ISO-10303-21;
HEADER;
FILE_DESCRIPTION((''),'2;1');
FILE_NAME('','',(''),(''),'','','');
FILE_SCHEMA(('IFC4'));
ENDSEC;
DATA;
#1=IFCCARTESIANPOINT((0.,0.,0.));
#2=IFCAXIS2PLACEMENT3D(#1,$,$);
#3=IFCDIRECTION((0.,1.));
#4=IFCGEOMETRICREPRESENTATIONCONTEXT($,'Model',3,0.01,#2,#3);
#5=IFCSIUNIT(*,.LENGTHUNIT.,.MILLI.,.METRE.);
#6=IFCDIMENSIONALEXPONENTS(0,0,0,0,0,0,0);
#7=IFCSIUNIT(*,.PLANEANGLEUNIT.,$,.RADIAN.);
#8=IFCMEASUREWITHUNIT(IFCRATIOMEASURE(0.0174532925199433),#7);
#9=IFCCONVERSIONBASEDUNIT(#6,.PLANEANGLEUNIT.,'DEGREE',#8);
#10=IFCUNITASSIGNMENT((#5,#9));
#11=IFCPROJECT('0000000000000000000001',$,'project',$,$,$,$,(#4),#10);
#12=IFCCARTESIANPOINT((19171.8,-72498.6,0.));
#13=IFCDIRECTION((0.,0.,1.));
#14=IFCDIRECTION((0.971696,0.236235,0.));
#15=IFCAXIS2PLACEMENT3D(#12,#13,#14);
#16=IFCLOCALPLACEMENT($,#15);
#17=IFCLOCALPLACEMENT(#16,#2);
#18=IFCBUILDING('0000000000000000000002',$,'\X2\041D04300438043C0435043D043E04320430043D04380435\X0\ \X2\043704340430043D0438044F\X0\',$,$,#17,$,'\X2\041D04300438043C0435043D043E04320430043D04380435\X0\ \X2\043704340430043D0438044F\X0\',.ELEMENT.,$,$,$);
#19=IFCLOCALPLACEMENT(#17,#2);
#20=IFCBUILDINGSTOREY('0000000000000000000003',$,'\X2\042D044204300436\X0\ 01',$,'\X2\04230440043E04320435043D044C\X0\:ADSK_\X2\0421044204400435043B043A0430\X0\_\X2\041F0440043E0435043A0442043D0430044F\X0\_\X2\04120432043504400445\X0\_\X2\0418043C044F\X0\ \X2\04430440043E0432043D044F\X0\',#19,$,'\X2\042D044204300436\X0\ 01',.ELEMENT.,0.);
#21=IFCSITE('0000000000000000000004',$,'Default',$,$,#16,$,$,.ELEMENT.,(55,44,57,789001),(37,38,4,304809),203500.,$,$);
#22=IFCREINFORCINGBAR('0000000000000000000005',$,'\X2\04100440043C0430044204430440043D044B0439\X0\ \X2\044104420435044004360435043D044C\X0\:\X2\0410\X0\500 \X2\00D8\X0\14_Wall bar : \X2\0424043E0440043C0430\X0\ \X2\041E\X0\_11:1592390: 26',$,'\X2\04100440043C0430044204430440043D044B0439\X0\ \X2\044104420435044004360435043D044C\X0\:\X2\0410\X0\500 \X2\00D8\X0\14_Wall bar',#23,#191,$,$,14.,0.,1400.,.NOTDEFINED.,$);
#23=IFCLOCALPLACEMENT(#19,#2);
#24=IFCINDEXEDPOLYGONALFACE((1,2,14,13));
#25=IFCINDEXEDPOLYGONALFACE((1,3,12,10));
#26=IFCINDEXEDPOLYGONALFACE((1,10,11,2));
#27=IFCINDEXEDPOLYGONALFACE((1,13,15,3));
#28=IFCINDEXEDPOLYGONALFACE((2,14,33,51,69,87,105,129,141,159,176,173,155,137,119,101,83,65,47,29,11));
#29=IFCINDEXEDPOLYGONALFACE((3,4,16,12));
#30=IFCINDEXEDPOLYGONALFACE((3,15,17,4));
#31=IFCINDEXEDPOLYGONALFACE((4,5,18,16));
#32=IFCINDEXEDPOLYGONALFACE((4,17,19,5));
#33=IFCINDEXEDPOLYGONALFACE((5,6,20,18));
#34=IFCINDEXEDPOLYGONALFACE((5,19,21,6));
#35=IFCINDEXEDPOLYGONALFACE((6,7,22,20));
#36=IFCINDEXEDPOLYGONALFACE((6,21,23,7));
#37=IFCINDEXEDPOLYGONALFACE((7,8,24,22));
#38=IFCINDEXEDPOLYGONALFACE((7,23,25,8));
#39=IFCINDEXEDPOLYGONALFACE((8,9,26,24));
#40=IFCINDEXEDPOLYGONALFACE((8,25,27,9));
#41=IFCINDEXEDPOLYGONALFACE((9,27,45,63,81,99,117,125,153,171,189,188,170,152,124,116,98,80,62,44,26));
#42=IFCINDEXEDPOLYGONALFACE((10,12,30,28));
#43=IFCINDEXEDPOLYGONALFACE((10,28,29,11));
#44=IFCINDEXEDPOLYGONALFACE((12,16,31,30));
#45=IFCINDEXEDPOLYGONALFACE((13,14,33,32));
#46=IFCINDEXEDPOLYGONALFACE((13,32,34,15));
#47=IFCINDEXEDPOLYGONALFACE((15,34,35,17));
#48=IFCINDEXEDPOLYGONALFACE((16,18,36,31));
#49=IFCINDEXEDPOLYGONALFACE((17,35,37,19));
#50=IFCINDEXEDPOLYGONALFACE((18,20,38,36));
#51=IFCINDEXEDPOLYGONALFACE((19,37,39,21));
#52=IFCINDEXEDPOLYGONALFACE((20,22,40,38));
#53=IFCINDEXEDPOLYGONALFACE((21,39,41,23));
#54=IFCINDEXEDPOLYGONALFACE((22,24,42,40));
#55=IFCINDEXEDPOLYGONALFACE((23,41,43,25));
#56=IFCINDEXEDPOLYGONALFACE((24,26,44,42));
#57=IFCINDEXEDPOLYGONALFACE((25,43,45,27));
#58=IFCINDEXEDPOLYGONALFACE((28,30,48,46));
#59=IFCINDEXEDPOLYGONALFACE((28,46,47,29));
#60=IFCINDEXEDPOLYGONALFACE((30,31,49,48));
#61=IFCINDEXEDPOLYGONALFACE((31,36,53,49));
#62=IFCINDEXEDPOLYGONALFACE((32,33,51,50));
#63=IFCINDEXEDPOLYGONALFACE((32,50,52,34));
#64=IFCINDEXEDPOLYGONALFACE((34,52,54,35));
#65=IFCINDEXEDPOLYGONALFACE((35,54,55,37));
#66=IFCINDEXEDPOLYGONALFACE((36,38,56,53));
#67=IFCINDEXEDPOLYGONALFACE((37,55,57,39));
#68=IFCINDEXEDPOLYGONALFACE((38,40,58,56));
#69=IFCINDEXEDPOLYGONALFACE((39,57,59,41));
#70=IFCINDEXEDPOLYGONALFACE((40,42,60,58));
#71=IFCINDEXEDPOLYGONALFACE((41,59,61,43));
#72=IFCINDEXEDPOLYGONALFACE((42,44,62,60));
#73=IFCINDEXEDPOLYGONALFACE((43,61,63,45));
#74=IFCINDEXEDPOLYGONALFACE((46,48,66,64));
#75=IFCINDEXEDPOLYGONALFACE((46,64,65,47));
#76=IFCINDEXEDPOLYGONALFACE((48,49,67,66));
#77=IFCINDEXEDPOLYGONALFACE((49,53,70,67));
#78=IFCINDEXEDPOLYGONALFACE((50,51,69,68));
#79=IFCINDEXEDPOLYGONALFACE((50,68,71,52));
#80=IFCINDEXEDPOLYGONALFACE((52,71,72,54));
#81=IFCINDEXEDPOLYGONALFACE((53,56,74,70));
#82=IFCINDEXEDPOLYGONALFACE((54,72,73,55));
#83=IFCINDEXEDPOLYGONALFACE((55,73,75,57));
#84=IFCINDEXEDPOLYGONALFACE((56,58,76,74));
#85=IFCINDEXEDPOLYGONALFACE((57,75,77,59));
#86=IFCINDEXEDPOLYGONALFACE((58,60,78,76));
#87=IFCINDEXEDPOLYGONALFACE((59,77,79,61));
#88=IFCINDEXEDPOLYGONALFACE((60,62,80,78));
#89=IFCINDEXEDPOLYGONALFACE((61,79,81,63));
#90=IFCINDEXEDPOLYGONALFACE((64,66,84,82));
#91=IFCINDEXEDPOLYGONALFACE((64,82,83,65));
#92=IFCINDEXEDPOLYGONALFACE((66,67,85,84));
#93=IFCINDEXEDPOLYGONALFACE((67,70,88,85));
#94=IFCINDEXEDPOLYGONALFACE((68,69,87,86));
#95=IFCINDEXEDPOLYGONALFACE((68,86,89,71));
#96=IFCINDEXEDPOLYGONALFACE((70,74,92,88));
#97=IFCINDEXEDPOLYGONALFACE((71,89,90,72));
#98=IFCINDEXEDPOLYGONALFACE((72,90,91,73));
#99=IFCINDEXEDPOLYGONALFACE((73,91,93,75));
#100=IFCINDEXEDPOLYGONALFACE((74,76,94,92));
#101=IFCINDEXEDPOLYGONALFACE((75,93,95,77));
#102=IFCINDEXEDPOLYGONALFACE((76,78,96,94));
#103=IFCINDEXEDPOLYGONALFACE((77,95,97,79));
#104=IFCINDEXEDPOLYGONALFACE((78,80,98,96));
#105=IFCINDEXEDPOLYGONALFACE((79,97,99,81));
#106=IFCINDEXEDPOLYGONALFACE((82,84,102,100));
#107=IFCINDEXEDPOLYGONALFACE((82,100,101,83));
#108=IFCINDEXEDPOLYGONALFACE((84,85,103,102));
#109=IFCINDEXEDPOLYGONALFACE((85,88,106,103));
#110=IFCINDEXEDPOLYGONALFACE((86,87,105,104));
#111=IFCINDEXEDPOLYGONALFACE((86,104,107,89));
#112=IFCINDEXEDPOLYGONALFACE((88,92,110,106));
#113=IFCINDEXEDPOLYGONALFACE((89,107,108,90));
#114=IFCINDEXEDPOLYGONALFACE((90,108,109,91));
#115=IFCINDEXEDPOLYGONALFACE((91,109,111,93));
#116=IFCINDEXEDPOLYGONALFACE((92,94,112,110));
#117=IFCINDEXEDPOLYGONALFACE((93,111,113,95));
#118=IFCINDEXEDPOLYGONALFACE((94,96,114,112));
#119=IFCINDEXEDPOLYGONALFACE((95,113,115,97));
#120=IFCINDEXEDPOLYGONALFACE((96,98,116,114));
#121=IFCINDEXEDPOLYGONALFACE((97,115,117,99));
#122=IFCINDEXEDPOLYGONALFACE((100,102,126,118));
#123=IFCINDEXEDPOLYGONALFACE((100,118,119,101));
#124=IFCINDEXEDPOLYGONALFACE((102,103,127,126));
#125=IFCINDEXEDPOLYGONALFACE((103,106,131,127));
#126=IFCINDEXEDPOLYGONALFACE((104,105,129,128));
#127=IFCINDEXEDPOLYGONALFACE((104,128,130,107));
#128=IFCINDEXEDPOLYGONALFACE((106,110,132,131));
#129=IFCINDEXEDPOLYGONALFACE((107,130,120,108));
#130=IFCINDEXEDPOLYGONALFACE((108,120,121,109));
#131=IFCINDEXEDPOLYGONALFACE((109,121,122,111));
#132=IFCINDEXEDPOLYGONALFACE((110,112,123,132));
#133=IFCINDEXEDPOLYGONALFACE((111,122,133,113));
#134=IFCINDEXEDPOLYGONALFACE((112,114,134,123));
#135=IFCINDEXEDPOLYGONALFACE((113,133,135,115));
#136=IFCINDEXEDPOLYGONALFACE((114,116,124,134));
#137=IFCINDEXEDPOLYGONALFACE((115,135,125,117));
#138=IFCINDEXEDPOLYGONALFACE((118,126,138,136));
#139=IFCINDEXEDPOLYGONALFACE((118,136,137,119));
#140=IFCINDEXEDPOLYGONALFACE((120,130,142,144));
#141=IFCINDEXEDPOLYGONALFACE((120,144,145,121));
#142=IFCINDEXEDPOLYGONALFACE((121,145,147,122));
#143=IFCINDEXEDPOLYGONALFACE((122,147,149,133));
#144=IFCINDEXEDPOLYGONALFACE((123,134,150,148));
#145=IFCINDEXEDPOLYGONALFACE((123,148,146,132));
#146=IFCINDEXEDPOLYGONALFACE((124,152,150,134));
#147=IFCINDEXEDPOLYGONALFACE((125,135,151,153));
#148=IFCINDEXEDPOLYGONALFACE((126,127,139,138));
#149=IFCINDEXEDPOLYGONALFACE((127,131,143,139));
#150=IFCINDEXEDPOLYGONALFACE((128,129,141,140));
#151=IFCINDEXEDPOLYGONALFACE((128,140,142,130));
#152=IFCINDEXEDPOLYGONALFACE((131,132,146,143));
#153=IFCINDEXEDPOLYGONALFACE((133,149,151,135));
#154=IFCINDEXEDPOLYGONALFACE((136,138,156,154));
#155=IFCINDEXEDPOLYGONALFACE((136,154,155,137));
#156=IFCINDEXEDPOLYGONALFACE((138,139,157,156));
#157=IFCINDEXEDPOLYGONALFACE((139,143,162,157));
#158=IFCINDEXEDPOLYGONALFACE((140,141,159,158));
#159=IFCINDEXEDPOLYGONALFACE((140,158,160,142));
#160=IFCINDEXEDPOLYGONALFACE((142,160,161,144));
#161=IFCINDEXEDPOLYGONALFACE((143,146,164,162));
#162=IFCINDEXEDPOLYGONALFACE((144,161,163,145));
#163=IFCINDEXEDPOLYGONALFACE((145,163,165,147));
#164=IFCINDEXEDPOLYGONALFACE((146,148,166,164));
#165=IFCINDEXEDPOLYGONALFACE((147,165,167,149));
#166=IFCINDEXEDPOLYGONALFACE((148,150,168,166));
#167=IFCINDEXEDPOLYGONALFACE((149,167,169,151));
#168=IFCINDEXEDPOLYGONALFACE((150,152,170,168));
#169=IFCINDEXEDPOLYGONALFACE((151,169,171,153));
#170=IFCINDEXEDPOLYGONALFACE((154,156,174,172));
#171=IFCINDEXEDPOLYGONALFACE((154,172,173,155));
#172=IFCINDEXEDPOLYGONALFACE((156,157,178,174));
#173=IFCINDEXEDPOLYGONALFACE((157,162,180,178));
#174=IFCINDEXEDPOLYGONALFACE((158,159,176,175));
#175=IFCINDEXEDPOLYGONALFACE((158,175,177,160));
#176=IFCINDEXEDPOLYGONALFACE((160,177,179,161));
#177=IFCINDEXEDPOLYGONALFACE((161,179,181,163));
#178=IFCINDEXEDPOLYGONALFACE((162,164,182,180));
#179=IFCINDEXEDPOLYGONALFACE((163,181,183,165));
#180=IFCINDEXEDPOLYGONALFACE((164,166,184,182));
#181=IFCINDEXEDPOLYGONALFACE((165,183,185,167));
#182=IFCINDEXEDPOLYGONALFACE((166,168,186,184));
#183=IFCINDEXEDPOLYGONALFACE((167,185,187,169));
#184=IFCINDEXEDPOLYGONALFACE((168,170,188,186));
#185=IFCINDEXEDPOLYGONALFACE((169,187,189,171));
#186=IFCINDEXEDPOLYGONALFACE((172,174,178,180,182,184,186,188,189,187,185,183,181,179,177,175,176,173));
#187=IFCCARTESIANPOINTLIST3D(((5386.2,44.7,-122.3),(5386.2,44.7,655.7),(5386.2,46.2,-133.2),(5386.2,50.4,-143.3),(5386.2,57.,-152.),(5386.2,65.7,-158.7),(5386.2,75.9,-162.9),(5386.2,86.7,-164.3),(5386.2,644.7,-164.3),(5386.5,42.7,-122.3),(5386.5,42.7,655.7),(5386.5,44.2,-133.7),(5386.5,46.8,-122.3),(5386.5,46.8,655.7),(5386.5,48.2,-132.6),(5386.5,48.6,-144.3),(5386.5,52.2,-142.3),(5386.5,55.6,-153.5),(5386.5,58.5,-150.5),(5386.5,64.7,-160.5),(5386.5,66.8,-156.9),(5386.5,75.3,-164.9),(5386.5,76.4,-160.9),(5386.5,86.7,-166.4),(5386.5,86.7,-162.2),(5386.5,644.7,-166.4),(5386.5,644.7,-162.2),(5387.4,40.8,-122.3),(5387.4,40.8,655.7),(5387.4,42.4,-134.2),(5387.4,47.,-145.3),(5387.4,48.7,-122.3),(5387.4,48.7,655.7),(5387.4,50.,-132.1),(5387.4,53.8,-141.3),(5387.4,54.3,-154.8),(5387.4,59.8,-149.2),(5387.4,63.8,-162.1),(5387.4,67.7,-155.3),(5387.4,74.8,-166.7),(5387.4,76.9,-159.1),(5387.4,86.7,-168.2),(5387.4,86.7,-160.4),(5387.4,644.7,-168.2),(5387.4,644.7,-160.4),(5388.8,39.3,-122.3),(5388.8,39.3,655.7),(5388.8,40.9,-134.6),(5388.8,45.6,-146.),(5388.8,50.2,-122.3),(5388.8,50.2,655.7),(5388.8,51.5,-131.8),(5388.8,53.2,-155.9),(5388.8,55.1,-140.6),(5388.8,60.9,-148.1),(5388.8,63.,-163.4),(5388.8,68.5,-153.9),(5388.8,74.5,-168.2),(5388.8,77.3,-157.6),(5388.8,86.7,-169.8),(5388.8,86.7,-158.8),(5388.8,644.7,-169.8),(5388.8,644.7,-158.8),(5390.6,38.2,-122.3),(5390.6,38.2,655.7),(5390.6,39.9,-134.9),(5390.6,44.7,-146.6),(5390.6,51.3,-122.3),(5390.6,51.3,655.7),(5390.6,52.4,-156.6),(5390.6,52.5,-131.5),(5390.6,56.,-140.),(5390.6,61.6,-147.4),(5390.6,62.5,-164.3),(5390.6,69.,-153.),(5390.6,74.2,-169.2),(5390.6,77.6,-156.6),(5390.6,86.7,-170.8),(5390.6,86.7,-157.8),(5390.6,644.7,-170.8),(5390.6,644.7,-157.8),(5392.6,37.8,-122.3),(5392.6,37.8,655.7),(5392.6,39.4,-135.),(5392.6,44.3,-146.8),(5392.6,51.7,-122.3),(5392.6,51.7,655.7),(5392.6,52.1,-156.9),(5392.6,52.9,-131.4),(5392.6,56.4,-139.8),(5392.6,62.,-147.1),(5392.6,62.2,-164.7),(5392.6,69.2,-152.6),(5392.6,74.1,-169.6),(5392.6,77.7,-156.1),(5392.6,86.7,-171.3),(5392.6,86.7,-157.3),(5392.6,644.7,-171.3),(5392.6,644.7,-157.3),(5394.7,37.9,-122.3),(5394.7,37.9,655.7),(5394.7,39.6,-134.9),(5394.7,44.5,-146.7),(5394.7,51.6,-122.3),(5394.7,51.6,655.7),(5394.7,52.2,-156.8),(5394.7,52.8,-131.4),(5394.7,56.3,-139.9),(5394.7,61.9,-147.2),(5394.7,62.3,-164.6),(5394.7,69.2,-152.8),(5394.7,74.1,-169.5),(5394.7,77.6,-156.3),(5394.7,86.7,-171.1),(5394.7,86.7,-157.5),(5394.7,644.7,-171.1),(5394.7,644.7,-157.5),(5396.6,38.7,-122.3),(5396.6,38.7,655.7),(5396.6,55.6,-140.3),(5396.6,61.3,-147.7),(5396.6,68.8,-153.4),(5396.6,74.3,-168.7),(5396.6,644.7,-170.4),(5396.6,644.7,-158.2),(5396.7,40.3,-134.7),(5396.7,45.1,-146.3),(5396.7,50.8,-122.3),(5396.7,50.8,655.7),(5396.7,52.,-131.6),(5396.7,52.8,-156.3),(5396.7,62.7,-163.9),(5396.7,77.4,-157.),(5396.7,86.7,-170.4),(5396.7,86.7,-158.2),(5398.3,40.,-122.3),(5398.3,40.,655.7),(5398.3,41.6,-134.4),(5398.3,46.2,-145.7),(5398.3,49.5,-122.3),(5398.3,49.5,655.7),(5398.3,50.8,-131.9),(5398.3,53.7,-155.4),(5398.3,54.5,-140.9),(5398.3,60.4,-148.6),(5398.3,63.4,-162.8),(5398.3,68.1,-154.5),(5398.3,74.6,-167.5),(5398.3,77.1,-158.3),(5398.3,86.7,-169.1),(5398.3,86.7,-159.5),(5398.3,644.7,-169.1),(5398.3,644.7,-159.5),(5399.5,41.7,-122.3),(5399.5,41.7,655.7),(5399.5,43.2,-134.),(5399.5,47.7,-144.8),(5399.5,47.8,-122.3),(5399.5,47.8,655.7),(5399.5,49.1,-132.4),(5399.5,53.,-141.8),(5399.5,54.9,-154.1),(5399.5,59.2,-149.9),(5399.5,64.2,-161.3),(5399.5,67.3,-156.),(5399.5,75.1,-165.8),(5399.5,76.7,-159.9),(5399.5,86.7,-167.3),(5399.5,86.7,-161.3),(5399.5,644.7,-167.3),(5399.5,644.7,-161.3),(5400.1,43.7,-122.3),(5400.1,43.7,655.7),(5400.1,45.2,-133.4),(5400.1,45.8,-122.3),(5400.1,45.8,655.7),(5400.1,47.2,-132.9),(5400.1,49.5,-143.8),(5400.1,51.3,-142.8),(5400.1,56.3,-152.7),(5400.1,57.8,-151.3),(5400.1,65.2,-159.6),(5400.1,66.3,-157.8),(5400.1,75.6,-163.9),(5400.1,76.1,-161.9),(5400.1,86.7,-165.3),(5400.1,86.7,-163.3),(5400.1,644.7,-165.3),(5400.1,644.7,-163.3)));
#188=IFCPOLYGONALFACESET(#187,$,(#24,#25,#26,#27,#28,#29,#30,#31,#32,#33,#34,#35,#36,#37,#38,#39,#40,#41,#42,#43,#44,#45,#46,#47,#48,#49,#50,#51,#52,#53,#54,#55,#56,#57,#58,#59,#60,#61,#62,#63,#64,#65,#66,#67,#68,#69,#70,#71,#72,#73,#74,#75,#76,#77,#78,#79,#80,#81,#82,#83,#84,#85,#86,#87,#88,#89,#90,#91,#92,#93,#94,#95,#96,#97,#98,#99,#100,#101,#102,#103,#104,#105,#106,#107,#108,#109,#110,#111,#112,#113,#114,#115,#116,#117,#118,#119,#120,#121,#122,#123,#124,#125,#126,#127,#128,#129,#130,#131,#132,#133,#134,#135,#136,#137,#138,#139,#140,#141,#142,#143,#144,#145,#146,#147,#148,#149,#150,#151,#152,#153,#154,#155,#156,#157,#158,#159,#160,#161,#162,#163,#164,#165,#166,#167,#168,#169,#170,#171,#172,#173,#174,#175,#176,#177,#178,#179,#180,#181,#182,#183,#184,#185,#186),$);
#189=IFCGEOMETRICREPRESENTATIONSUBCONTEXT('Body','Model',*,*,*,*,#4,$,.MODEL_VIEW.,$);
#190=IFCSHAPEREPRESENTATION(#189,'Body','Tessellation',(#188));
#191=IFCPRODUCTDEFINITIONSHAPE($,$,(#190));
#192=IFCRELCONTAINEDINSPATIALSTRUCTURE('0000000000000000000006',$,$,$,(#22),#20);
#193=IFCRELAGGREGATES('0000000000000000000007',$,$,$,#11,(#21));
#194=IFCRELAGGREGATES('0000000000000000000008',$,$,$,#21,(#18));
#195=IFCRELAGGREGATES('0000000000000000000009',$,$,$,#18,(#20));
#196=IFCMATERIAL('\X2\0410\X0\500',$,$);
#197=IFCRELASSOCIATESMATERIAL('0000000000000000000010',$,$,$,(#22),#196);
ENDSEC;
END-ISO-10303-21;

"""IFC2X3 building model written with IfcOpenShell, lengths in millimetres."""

from ifc_helpers import new_model, entity, si_unit, converted_unit, direction, frame, origin, place, context, subcontext, project, spatial, material, element, save


model = new_model("IFC2X3")

# Units and contexts
model_context = context("Model", 3, precision=0.01, world=origin(), true_north=direction((0.0, 1.0)))
body_context = subcontext(model_context, "Body", "Model", "MODEL_VIEW")
ifc_project = project(units=[si_unit("LENGTHUNIT", "METRE", prefix="MILLI"), converted_unit("PLANEANGLEUNIT", "DEGREE", entity("IfcRatioMeasure", 0.0174532925199433), si_unit("PLANEANGLEUNIT", "RADIAN"), dimensions=[0, 0, 0, 0, 0, 0, 0])], contexts=[model_context])

# Site, building, storey
site_placement = place(None, frame((19171.8, -72498.6, 0.0), z_axis=(0.0, 0.0, 1.0), x_axis=(0.971696, 0.236235, 0.0)))
site = spatial("IfcSite", under=ifc_project, at=site_placement, Name="Default", CompositionType="ELEMENT", RefLatitude=(55, 44, 57, 789001), RefLongitude=(37, 38, 4, 304809), RefElevation=203500.0)
building_placement = place(site_placement, origin())
building = spatial("IfcBuilding", under=site, at=building_placement, Name="Наименование здания", LongName="Наименование здания", CompositionType="ELEMENT")
storey_placement = place(building_placement, origin())
storey = spatial("IfcBuildingStorey", under=building, at=storey_placement, Name="Этаж 01", ObjectType="Уровень:ADSK_Стрелка_Проектная_Вверх_Имя уровня", LongName="Этаж 01", CompositionType="ELEMENT", Elevation=0.0)

# Reinforcing bar
ifc_material = material(Name="А500")
placement = place(storey_placement, origin())
element("IfcReinforcingBar", 1, at=placement, inside=storey, material=ifc_material, Name="Арматурный стержень:А500 Ø14_Wall bar : Форма О_11:1592390: 26", ObjectType="Арматурный стержень:А500 Ø14_Wall bar", BarLength=1400.0, BarRole="NOTDEFINED", CrossSectionArea=0.0, NominalDiameter=14.0, context=body_context, shape_type="AdvancedSweptSolid", body=[
    entity("IfcSweptDiskSolid", entity("IfcCompositeCurve", [entity("IfcCompositeCurveSegment", "CONTINUOUS", True, entity("IfcPolyline", [entity("IfcCartesianPoint", [5393.1, 44.7, 655.7]), entity("IfcCartesianPoint", [5393.1, 44.7, -122.3])])), entity("IfcCompositeCurveSegment", "CONTINUOUS", True, entity("IfcTrimmedCurve", entity("IfcCircle", entity("IfcAxis2Placement3D", entity("IfcCartesianPoint", [5393.1, 86.7, -122.3]), entity("IfcDirection", [1.0, 0.0, 0.0]), entity("IfcDirection", [0.0, 0.0, -1.0])), 42.0), [entity("IfcParameterValue", 270.0)], [entity("IfcParameterValue", 360.0)], True, "PARAMETER")), entity("IfcCompositeCurveSegment", "CONTINUOUS", True, entity("IfcPolyline", [entity("IfcCartesianPoint", [5393.1, 86.7, -164.3]), entity("IfcCartesianPoint", [5393.1, 644.7, -164.3])]))], False), 7.0, None, 0.0, 92.0),
])

save(model, "model.ifc")
